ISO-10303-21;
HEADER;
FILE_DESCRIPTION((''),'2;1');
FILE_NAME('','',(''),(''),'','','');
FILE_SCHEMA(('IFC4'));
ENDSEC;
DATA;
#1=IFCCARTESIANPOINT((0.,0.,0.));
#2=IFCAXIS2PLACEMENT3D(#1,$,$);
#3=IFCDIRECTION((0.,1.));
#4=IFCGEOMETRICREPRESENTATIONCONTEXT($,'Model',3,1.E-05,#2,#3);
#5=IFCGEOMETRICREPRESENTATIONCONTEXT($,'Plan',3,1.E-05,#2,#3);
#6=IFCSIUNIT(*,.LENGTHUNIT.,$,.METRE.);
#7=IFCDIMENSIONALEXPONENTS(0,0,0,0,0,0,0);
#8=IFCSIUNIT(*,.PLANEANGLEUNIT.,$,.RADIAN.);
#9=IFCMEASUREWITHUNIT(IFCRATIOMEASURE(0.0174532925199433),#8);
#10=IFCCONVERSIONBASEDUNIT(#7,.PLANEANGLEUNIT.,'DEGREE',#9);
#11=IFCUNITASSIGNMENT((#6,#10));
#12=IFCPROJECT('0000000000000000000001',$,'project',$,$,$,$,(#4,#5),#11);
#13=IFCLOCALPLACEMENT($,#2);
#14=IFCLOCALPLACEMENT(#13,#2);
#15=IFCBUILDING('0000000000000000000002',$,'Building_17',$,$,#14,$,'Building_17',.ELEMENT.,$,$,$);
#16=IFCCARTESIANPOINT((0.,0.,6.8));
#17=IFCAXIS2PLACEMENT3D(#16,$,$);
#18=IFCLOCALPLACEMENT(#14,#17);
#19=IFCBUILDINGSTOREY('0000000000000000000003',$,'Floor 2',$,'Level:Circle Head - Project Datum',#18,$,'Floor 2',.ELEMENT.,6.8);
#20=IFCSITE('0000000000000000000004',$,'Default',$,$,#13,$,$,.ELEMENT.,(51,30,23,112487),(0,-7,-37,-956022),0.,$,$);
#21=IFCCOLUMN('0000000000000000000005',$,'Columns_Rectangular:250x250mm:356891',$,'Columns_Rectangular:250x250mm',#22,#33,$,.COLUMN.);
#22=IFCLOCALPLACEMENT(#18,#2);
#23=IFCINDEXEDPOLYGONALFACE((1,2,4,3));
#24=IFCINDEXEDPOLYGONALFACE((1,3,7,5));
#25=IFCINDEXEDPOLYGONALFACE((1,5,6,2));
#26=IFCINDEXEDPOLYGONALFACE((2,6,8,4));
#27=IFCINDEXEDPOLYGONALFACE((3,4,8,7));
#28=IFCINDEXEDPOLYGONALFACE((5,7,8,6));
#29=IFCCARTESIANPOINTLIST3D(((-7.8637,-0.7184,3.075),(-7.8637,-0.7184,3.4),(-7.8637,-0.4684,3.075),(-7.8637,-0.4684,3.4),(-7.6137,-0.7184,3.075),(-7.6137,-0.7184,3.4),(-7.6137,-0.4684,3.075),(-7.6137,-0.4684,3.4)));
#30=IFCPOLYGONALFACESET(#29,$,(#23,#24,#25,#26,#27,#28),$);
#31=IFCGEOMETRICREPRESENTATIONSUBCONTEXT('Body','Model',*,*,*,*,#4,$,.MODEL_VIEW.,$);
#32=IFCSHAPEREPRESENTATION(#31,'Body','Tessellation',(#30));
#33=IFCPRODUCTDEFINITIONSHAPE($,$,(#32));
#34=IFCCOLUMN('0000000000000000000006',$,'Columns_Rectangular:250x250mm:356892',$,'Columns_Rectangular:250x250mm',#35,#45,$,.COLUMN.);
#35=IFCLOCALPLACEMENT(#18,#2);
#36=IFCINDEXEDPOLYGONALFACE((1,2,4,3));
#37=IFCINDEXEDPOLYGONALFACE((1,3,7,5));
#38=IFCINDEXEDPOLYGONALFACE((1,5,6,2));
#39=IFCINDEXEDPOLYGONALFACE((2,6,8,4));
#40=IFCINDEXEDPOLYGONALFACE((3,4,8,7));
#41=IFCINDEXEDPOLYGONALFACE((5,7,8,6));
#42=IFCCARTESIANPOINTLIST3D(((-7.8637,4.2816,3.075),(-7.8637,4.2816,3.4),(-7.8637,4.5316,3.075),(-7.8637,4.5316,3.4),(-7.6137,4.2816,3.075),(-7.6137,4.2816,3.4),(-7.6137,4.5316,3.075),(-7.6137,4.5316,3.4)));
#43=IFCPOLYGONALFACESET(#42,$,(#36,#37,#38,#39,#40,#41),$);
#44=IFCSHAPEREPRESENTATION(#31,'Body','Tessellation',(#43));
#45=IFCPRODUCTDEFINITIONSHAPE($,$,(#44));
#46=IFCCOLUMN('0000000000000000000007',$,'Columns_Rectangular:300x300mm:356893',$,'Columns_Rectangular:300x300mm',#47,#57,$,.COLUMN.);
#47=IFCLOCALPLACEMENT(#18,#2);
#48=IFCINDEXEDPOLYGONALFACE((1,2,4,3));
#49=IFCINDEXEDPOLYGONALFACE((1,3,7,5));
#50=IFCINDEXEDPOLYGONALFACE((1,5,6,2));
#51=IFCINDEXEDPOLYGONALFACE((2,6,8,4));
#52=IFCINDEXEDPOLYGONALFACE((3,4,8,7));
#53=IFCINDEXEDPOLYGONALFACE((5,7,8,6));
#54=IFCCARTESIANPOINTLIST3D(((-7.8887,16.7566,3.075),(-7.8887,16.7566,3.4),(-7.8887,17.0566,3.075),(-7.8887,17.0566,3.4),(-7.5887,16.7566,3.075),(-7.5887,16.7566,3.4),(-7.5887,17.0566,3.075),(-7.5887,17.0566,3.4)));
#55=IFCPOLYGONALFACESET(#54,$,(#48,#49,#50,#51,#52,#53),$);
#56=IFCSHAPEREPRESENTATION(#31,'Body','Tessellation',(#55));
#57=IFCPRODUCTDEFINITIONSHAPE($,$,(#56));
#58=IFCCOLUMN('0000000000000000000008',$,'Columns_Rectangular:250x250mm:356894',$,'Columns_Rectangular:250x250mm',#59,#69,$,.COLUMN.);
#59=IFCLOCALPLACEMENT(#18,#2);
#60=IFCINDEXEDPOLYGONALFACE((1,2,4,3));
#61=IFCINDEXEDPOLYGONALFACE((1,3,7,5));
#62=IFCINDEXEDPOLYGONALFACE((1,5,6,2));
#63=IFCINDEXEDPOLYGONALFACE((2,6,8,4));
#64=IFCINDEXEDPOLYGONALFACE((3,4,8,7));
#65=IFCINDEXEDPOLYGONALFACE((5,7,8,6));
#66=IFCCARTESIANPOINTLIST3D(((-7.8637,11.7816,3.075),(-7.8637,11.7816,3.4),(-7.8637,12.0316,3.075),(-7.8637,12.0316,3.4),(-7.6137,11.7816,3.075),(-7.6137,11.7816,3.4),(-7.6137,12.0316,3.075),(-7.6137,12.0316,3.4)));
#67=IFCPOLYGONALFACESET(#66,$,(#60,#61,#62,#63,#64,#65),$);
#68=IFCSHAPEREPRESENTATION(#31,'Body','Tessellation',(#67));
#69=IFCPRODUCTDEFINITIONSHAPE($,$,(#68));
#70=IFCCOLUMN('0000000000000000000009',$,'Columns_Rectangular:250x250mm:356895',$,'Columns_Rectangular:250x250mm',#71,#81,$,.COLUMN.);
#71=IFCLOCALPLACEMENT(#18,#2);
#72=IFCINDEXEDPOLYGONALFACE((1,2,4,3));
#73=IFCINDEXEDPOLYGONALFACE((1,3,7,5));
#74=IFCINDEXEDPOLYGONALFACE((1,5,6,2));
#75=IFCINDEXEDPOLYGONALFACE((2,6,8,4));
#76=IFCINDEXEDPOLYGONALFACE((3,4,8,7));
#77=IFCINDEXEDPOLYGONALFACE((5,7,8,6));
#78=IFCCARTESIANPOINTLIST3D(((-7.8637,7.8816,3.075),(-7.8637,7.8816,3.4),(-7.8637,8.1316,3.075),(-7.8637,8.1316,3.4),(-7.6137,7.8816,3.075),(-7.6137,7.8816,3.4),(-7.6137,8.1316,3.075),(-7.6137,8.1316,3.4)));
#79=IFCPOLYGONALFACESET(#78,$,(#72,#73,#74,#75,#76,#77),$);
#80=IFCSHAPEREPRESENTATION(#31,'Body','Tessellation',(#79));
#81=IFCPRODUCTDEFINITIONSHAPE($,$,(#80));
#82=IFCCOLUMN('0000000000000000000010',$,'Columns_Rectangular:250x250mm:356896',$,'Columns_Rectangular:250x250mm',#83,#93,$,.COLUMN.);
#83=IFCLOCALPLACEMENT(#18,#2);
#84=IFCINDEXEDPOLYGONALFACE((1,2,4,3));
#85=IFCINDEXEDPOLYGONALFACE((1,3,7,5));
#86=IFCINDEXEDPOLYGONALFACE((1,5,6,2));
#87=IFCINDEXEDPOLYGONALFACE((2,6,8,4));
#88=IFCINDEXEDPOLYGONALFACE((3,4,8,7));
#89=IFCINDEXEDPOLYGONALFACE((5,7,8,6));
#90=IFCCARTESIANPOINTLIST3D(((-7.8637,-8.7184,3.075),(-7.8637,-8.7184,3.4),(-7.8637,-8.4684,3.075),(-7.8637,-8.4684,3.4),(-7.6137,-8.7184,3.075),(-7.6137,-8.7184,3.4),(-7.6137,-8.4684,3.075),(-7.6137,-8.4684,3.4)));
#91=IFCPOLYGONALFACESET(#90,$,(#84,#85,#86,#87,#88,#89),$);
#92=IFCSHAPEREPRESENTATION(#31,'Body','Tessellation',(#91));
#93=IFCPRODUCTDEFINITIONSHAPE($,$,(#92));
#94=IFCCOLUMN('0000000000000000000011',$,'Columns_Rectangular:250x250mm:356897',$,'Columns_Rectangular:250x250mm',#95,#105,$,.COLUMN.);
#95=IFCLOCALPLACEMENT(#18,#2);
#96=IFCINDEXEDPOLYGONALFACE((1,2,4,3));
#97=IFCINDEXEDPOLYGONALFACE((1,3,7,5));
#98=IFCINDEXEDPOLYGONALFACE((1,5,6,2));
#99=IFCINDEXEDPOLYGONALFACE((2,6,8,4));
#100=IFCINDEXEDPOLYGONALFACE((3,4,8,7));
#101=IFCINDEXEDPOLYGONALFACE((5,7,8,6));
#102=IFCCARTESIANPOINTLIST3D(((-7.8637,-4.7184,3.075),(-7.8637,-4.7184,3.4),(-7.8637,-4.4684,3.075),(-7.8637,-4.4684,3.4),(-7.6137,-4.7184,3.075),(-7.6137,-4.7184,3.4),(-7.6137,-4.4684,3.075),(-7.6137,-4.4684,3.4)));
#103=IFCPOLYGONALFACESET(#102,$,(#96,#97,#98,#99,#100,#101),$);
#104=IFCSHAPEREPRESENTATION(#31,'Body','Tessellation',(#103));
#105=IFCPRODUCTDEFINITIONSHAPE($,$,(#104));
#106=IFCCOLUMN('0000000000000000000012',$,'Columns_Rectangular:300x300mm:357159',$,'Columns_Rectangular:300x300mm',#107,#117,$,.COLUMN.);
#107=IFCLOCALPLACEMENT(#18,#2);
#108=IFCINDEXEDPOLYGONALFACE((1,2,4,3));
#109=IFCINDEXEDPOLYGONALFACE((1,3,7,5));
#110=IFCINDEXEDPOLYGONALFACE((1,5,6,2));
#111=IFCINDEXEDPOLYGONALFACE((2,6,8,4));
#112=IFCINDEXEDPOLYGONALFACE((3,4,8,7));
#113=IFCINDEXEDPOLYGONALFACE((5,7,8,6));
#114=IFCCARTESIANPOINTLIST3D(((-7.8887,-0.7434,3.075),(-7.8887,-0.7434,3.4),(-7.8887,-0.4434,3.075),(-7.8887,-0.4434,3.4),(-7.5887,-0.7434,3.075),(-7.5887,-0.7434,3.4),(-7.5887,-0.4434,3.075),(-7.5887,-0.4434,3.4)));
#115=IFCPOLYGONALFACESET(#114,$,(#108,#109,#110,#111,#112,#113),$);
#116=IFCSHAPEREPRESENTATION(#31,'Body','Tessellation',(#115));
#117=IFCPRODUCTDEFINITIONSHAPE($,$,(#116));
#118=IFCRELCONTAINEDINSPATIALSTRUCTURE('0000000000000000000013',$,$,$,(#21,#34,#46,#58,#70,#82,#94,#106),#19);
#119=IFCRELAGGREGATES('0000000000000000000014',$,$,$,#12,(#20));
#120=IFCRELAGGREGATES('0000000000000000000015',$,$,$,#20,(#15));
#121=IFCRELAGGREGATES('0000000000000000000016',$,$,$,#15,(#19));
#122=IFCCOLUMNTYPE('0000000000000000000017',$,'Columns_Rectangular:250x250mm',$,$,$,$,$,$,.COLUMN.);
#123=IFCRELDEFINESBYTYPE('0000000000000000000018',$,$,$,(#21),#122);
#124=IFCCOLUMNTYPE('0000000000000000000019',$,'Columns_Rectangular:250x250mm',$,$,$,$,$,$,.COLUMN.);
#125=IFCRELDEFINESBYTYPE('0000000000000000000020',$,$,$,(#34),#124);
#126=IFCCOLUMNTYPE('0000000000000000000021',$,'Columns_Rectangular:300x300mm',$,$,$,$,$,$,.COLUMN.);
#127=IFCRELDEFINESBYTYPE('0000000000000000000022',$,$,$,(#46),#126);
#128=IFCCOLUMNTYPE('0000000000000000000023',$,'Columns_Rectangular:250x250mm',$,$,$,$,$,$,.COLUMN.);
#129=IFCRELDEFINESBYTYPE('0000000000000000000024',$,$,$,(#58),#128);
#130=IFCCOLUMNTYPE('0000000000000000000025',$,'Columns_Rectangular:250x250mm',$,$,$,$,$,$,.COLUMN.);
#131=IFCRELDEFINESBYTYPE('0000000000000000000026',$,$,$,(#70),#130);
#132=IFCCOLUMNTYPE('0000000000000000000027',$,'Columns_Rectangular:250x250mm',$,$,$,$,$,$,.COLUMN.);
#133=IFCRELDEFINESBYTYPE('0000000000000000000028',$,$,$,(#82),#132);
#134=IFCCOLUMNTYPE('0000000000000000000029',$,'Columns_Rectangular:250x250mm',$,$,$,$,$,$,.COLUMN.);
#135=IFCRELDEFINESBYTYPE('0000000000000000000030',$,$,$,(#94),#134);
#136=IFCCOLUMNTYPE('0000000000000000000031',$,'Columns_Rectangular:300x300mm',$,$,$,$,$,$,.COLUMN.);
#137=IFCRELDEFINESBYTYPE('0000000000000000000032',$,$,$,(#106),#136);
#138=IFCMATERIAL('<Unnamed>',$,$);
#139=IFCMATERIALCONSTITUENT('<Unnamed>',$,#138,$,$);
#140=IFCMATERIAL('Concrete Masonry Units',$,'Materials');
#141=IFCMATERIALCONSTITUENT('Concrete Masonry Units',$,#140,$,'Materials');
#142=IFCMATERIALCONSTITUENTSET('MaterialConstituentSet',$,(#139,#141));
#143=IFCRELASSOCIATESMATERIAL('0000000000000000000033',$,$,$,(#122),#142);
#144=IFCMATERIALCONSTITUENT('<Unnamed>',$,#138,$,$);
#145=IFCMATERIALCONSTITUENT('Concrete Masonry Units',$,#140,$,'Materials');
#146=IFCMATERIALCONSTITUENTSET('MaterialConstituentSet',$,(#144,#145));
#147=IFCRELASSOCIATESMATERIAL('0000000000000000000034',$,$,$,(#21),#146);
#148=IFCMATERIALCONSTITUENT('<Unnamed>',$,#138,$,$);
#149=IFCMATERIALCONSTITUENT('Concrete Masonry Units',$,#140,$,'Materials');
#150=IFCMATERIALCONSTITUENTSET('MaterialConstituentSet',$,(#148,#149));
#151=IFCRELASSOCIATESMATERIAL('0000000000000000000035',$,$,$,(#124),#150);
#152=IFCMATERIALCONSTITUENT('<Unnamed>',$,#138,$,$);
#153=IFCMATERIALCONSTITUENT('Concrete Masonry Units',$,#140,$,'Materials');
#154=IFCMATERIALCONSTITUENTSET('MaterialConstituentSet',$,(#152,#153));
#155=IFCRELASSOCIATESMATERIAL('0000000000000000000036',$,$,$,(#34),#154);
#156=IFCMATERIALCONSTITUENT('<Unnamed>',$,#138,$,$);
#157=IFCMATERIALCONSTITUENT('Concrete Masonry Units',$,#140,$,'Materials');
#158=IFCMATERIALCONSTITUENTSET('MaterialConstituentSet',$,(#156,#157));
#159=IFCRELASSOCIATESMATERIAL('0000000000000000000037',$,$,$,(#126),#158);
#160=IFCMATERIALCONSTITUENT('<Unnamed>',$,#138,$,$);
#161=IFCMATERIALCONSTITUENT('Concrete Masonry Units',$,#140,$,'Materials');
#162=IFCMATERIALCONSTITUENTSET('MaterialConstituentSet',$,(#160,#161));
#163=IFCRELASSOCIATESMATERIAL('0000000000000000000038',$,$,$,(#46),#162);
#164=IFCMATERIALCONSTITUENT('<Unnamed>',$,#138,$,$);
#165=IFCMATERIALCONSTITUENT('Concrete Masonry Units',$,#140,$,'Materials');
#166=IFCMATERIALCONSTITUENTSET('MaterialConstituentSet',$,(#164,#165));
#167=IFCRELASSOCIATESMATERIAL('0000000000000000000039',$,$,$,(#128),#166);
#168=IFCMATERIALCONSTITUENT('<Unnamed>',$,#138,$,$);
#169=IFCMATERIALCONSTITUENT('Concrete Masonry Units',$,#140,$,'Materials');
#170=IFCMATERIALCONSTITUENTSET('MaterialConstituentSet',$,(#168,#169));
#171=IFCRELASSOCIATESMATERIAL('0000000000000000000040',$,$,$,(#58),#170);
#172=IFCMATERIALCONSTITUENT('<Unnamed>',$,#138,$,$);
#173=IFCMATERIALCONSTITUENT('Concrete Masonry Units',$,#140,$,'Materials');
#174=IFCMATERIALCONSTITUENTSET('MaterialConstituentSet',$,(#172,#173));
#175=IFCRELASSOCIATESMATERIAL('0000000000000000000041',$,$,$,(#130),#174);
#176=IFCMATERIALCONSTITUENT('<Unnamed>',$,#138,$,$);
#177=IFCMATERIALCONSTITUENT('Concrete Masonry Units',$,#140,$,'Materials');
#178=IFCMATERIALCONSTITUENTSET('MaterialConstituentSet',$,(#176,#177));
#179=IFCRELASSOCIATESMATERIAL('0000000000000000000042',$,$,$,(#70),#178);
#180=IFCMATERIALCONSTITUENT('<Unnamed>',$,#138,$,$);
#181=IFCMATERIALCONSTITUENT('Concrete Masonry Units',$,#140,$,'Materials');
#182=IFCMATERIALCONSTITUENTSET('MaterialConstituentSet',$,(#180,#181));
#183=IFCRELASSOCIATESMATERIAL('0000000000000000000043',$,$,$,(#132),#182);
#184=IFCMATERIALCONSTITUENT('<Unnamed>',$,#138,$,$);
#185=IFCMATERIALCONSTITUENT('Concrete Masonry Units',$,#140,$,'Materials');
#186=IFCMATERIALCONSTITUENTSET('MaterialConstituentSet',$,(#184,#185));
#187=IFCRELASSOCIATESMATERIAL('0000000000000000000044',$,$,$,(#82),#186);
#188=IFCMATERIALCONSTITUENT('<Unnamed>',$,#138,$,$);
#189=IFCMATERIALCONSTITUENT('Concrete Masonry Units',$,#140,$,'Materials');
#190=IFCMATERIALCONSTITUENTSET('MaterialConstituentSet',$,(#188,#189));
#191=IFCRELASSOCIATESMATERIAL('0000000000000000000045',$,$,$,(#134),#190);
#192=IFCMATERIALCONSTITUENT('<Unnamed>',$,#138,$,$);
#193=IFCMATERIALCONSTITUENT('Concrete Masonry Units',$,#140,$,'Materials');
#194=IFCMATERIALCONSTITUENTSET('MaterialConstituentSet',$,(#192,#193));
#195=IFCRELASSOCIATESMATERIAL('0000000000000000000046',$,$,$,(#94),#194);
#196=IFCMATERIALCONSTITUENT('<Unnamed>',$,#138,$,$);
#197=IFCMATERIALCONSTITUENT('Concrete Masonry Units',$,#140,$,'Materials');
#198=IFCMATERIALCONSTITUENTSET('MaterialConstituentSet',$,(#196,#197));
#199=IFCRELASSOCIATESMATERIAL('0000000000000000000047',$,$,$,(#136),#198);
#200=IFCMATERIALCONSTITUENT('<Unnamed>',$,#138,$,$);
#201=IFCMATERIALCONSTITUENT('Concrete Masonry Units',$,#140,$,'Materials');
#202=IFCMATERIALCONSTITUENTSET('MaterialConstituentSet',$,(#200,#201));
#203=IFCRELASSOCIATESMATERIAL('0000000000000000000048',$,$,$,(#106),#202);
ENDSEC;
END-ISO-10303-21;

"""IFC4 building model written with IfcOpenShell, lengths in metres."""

from ifc_helpers import new_model, entity, si_unit, converted_unit, direction, frame, origin, place, context, subcontext, project, spatial, indexed_curve, outline, extrude, source, transform, mapped, material, constituent, constituent_set, type_object, type_shapes, element, save


model = new_model("IFC4")

# Units and contexts
model_context = context("Model", 3, precision=1e-05, world=origin(), true_north=direction((0.0, 1.0)))
plan_context = context("Plan", 3, precision=1e-05, world=origin(), true_north=direction((0.0, 1.0)))
body_context = subcontext(model_context, "Body", "Model", "MODEL_VIEW")
ifc_project = project(units=[si_unit("LENGTHUNIT", "METRE"), converted_unit("PLANEANGLEUNIT", "DEGREE", entity("IfcRatioMeasure", 0.0174532925199433), si_unit("PLANEANGLEUNIT", "RADIAN"), dimensions=[0, 0, 0, 0, 0, 0, 0])], contexts=[model_context, plan_context])

# Site, building, storey
site_placement = place(None, origin())
site = spatial("IfcSite", under=ifc_project, at=site_placement, Name="Default", CompositionType="ELEMENT", RefLatitude=(51, 30, 23, 112487), RefLongitude=(0, -7, -37, -956022), RefElevation=0.0)
building_placement = place(site_placement, origin())
building = spatial("IfcBuilding", under=site, at=building_placement, Name="Building_17", LongName="Building_17", CompositionType="ELEMENT")
storey_placement = place(building_placement, frame((0.0, 0.0, 6.8)))
storey = spatial("IfcBuildingStorey", under=building, at=storey_placement, Name="Floor 2", ObjectType="Level:Circle Head - Project Datum", LongName="Floor 2", CompositionType="ELEMENT", Elevation=6.8)

# Columns
ifc_material_1 = material(Name="<Unnamed>")
ifc_constituent_1 = constituent(ifc_material_1, Name="<Unnamed>")
ifc_material_2 = material(Name="Concrete Masonry Units", Category="Materials")
ifc_constituent_2 = constituent(ifc_material_2, Name="Concrete Masonry Units", Category="Materials")
ifc_constituent_set_1 = constituent_set(constituents=[ifc_constituent_1, ifc_constituent_2], Name="MaterialConstituentSet")
ifc_constituent_3 = constituent(ifc_material_1, Name="<Unnamed>")
ifc_constituent_4 = constituent(ifc_material_2, Name="Concrete Masonry Units", Category="Materials")
ifc_constituent_set_2 = constituent_set(constituents=[ifc_constituent_3, ifc_constituent_4], Name="MaterialConstituentSet")
column_type_1 = type_object("IfcColumnType", Name="Columns_Rectangular:250x250mm", PredefinedType="COLUMN", material=ifc_constituent_set_2)
shared_shape_1 = source(origin(), body_context, "Body", "SweptSolid", [
    extrude(outline(indexed_curve([(-0.125, -0.125), (0.125, -0.125), (0.125, 0.125), (-0.125, 0.125), (-0.125, -0.125)], self_intersect=False)), frame((-7.7387, -0.5934, 9.875), z_axis=(0.0, 0.0, 1.0), x_axis=(0.0, -1.0, 0.0)), (0.0, 0.0, 1.0), 0.325),
])
type_shapes(column_type_1, [shared_shape_1])
column_1_placement = place(storey_placement, frame((0.0, 0.0, -6.8)))
element("IfcColumn", 1, at=column_1_placement, inside=storey, type_object=column_type_1, material=ifc_constituent_set_1, Name="Columns_Rectangular:250x250mm:356891", ObjectType="Columns_Rectangular:250x250mm", PredefinedType="COLUMN", context=body_context, shape_type="MappedRepresentation", body=[
    mapped(shared_shape_1, transform((0.0, 0.0, 0.0), scale=1.0)),
])
ifc_constituent_5 = constituent(ifc_material_1, Name="<Unnamed>")
ifc_constituent_6 = constituent(ifc_material_2, Name="Concrete Masonry Units", Category="Materials")
ifc_constituent_set_3 = constituent_set(constituents=[ifc_constituent_5, ifc_constituent_6], Name="MaterialConstituentSet")
ifc_constituent_7 = constituent(ifc_material_1, Name="<Unnamed>")
ifc_constituent_8 = constituent(ifc_material_2, Name="Concrete Masonry Units", Category="Materials")
ifc_constituent_set_4 = constituent_set(constituents=[ifc_constituent_7, ifc_constituent_8], Name="MaterialConstituentSet")
column_type_2 = type_object("IfcColumnType", Name="Columns_Rectangular:250x250mm", PredefinedType="COLUMN", material=ifc_constituent_set_4)
shared_shape_2 = source(origin(), body_context, "Body", "SweptSolid", [
    extrude(outline(indexed_curve([(-0.125, -0.125), (0.125, -0.125), (0.125, 0.125), (-0.125, 0.125), (-0.125, -0.125)], self_intersect=False)), frame((-7.7387, 4.4066, 9.875), z_axis=(0.0, 0.0, 1.0), x_axis=(0.0, -1.0, 0.0)), (0.0, 0.0, 1.0), 0.325),
])
type_shapes(column_type_2, [shared_shape_2])
column_2_placement = place(storey_placement, frame((0.0, 0.0, -6.8)))
element("IfcColumn", 2, at=column_2_placement, inside=storey, type_object=column_type_2, material=ifc_constituent_set_3, Name="Columns_Rectangular:250x250mm:356892", ObjectType="Columns_Rectangular:250x250mm", PredefinedType="COLUMN", context=body_context, shape_type="MappedRepresentation", body=[
    mapped(shared_shape_2, transform((0.0, 0.0, 0.0), scale=1.0)),
])
ifc_constituent_9 = constituent(ifc_material_1, Name="<Unnamed>")
ifc_constituent_10 = constituent(ifc_material_2, Name="Concrete Masonry Units", Category="Materials")
ifc_constituent_set_5 = constituent_set(constituents=[ifc_constituent_9, ifc_constituent_10], Name="MaterialConstituentSet")
ifc_constituent_11 = constituent(ifc_material_1, Name="<Unnamed>")
ifc_constituent_12 = constituent(ifc_material_2, Name="Concrete Masonry Units", Category="Materials")
ifc_constituent_set_6 = constituent_set(constituents=[ifc_constituent_11, ifc_constituent_12], Name="MaterialConstituentSet")
column_type_3 = type_object("IfcColumnType", Name="Columns_Rectangular:300x300mm", PredefinedType="COLUMN", material=ifc_constituent_set_6)
shared_shape_3 = source(origin(), body_context, "Body", "SweptSolid", [
    extrude(outline(indexed_curve([(-0.15, -0.15), (0.15, -0.15), (0.15, 0.15), (-0.15, 0.15), (-0.15, -0.15)], self_intersect=False)), frame((-7.7387, 16.9066, 9.875), z_axis=(0.0, 0.0, 1.0), x_axis=(0.0, -1.0, 0.0)), (0.0, 0.0, 1.0), 0.325),
])
type_shapes(column_type_3, [shared_shape_3])
column_3_placement = place(storey_placement, frame((0.0, 0.0, -6.8)))
element("IfcColumn", 3, at=column_3_placement, inside=storey, type_object=column_type_3, material=ifc_constituent_set_5, Name="Columns_Rectangular:300x300mm:356893", ObjectType="Columns_Rectangular:300x300mm", PredefinedType="COLUMN", context=body_context, shape_type="MappedRepresentation", body=[
    mapped(shared_shape_3, transform((0.0, 0.0, 0.0), scale=1.0)),
])
ifc_constituent_13 = constituent(ifc_material_1, Name="<Unnamed>")
ifc_constituent_14 = constituent(ifc_material_2, Name="Concrete Masonry Units", Category="Materials")
ifc_constituent_set_7 = constituent_set(constituents=[ifc_constituent_13, ifc_constituent_14], Name="MaterialConstituentSet")
ifc_constituent_15 = constituent(ifc_material_1, Name="<Unnamed>")
ifc_constituent_16 = constituent(ifc_material_2, Name="Concrete Masonry Units", Category="Materials")
ifc_constituent_set_8 = constituent_set(constituents=[ifc_constituent_15, ifc_constituent_16], Name="MaterialConstituentSet")
column_type_4 = type_object("IfcColumnType", Name="Columns_Rectangular:250x250mm", PredefinedType="COLUMN", material=ifc_constituent_set_8)
shared_shape_4 = source(origin(), body_context, "Body", "SweptSolid", [
    extrude(outline(indexed_curve([(-0.125, -0.125), (0.125, -0.125), (0.125, 0.125), (-0.125, 0.125), (-0.125, -0.125)], self_intersect=False)), frame((-7.7387, 11.9066, 9.875), z_axis=(0.0, 0.0, 1.0), x_axis=(0.0, -1.0, 0.0)), (0.0, 0.0, 1.0), 0.325),
])
type_shapes(column_type_4, [shared_shape_4])
column_4_placement = place(storey_placement, frame((0.0, 0.0, -6.8)))
element("IfcColumn", 4, at=column_4_placement, inside=storey, type_object=column_type_4, material=ifc_constituent_set_7, Name="Columns_Rectangular:250x250mm:356894", ObjectType="Columns_Rectangular:250x250mm", PredefinedType="COLUMN", context=body_context, shape_type="MappedRepresentation", body=[
    mapped(shared_shape_4, transform((0.0, 0.0, 0.0), scale=1.0)),
])
ifc_constituent_17 = constituent(ifc_material_1, Name="<Unnamed>")
ifc_constituent_18 = constituent(ifc_material_2, Name="Concrete Masonry Units", Category="Materials")
ifc_constituent_set_9 = constituent_set(constituents=[ifc_constituent_17, ifc_constituent_18], Name="MaterialConstituentSet")
ifc_constituent_19 = constituent(ifc_material_1, Name="<Unnamed>")
ifc_constituent_20 = constituent(ifc_material_2, Name="Concrete Masonry Units", Category="Materials")
ifc_constituent_set_10 = constituent_set(constituents=[ifc_constituent_19, ifc_constituent_20], Name="MaterialConstituentSet")
column_type_5 = type_object("IfcColumnType", Name="Columns_Rectangular:250x250mm", PredefinedType="COLUMN", material=ifc_constituent_set_10)
shared_shape_5 = source(origin(), body_context, "Body", "SweptSolid", [
    extrude(outline(indexed_curve([(-0.125, -0.125), (0.125, -0.125), (0.125, 0.125), (-0.125, 0.125), (-0.125, -0.125)], self_intersect=False)), frame((-7.7387, 8.0066, 9.875), z_axis=(0.0, 0.0, 1.0), x_axis=(0.0, -1.0, 0.0)), (0.0, 0.0, 1.0), 0.325),
])
type_shapes(column_type_5, [shared_shape_5])
column_5_placement = place(storey_placement, frame((0.0, 0.0, -6.8)))
element("IfcColumn", 5, at=column_5_placement, inside=storey, type_object=column_type_5, material=ifc_constituent_set_9, Name="Columns_Rectangular:250x250mm:356895", ObjectType="Columns_Rectangular:250x250mm", PredefinedType="COLUMN", context=body_context, shape_type="MappedRepresentation", body=[
    mapped(shared_shape_5, transform((0.0, 0.0, 0.0), scale=1.0)),
])
ifc_constituent_21 = constituent(ifc_material_1, Name="<Unnamed>")
ifc_constituent_22 = constituent(ifc_material_2, Name="Concrete Masonry Units", Category="Materials")
ifc_constituent_set_11 = constituent_set(constituents=[ifc_constituent_21, ifc_constituent_22], Name="MaterialConstituentSet")
ifc_constituent_23 = constituent(ifc_material_1, Name="<Unnamed>")
ifc_constituent_24 = constituent(ifc_material_2, Name="Concrete Masonry Units", Category="Materials")
ifc_constituent_set_12 = constituent_set(constituents=[ifc_constituent_23, ifc_constituent_24], Name="MaterialConstituentSet")
column_type_6 = type_object("IfcColumnType", Name="Columns_Rectangular:250x250mm", PredefinedType="COLUMN", material=ifc_constituent_set_12)
shared_shape_6 = source(origin(), body_context, "Body", "SweptSolid", [
    extrude(outline(indexed_curve([(-0.125, -0.125), (0.125, -0.125), (0.125, 0.125), (-0.125, 0.125), (-0.125, -0.125)], self_intersect=False)), frame((-7.7387, -8.5934, 9.875), z_axis=(0.0, 0.0, 1.0), x_axis=(0.0, -1.0, 0.0)), (0.0, 0.0, 1.0), 0.325),
])
type_shapes(column_type_6, [shared_shape_6])
column_6_placement = place(storey_placement, frame((0.0, 0.0, -6.8)))
element("IfcColumn", 6, at=column_6_placement, inside=storey, type_object=column_type_6, material=ifc_constituent_set_11, Name="Columns_Rectangular:250x250mm:356896", ObjectType="Columns_Rectangular:250x250mm", PredefinedType="COLUMN", context=body_context, shape_type="MappedRepresentation", body=[
    mapped(shared_shape_6, transform((0.0, 0.0, 0.0), scale=1.0)),
])
ifc_constituent_25 = constituent(ifc_material_1, Name="<Unnamed>")
ifc_constituent_26 = constituent(ifc_material_2, Name="Concrete Masonry Units", Category="Materials")
ifc_constituent_set_13 = constituent_set(constituents=[ifc_constituent_25, ifc_constituent_26], Name="MaterialConstituentSet")
ifc_constituent_27 = constituent(ifc_material_1, Name="<Unnamed>")
ifc_constituent_28 = constituent(ifc_material_2, Name="Concrete Masonry Units", Category="Materials")
ifc_constituent_set_14 = constituent_set(constituents=[ifc_constituent_27, ifc_constituent_28], Name="MaterialConstituentSet")
column_type_7 = type_object("IfcColumnType", Name="Columns_Rectangular:250x250mm", PredefinedType="COLUMN", material=ifc_constituent_set_14)
shared_shape_7 = source(origin(), body_context, "Body", "SweptSolid", [
    extrude(outline(indexed_curve([(-0.125, -0.125), (0.125, -0.125), (0.125, 0.125), (-0.125, 0.125), (-0.125, -0.125)], self_intersect=False)), frame((-7.7387, -4.5934, 9.875), z_axis=(0.0, 0.0, 1.0), x_axis=(0.0, -1.0, 0.0)), (0.0, 0.0, 1.0), 0.325),
])
type_shapes(column_type_7, [shared_shape_7])
column_7_placement = place(storey_placement, frame((0.0, 0.0, -6.8)))
element("IfcColumn", 7, at=column_7_placement, inside=storey, type_object=column_type_7, material=ifc_constituent_set_13, Name="Columns_Rectangular:250x250mm:356897", ObjectType="Columns_Rectangular:250x250mm", PredefinedType="COLUMN", context=body_context, shape_type="MappedRepresentation", body=[
    mapped(shared_shape_7, transform((0.0, 0.0, 0.0), scale=1.0)),
])
ifc_constituent_29 = constituent(ifc_material_1, Name="<Unnamed>")
ifc_constituent_30 = constituent(ifc_material_2, Name="Concrete Masonry Units", Category="Materials")
ifc_constituent_set_15 = constituent_set(constituents=[ifc_constituent_29, ifc_constituent_30], Name="MaterialConstituentSet")
ifc_constituent_31 = constituent(ifc_material_1, Name="<Unnamed>")
ifc_constituent_32 = constituent(ifc_material_2, Name="Concrete Masonry Units", Category="Materials")
ifc_constituent_set_16 = constituent_set(constituents=[ifc_constituent_31, ifc_constituent_32], Name="MaterialConstituentSet")
column_type_8 = type_object("IfcColumnType", Name="Columns_Rectangular:300x300mm", PredefinedType="COLUMN", material=ifc_constituent_set_16)
shared_shape_8 = source(origin(), body_context, "Body", "SweptSolid", [
    extrude(outline(indexed_curve([(-0.15, -0.15), (0.15, -0.15), (0.15, 0.15), (-0.15, 0.15), (-0.15, -0.15)], self_intersect=False)), frame((-7.7387, -0.5934, 9.875), z_axis=(0.0, 0.0, 1.0), x_axis=(0.0, -1.0, 0.0)), (0.0, 0.0, 1.0), 0.325),
])
type_shapes(column_type_8, [shared_shape_8])
column_8_placement = place(storey_placement, frame((0.0, 0.0, -6.8)))
element("IfcColumn", 8, at=column_8_placement, inside=storey, type_object=column_type_8, material=ifc_constituent_set_15, Name="Columns_Rectangular:300x300mm:357159", ObjectType="Columns_Rectangular:300x300mm", PredefinedType="COLUMN", context=body_context, shape_type="MappedRepresentation", body=[
    mapped(shared_shape_8, transform((0.0, 0.0, 0.0), scale=1.0)),
])

save(model, "model.ifc")
